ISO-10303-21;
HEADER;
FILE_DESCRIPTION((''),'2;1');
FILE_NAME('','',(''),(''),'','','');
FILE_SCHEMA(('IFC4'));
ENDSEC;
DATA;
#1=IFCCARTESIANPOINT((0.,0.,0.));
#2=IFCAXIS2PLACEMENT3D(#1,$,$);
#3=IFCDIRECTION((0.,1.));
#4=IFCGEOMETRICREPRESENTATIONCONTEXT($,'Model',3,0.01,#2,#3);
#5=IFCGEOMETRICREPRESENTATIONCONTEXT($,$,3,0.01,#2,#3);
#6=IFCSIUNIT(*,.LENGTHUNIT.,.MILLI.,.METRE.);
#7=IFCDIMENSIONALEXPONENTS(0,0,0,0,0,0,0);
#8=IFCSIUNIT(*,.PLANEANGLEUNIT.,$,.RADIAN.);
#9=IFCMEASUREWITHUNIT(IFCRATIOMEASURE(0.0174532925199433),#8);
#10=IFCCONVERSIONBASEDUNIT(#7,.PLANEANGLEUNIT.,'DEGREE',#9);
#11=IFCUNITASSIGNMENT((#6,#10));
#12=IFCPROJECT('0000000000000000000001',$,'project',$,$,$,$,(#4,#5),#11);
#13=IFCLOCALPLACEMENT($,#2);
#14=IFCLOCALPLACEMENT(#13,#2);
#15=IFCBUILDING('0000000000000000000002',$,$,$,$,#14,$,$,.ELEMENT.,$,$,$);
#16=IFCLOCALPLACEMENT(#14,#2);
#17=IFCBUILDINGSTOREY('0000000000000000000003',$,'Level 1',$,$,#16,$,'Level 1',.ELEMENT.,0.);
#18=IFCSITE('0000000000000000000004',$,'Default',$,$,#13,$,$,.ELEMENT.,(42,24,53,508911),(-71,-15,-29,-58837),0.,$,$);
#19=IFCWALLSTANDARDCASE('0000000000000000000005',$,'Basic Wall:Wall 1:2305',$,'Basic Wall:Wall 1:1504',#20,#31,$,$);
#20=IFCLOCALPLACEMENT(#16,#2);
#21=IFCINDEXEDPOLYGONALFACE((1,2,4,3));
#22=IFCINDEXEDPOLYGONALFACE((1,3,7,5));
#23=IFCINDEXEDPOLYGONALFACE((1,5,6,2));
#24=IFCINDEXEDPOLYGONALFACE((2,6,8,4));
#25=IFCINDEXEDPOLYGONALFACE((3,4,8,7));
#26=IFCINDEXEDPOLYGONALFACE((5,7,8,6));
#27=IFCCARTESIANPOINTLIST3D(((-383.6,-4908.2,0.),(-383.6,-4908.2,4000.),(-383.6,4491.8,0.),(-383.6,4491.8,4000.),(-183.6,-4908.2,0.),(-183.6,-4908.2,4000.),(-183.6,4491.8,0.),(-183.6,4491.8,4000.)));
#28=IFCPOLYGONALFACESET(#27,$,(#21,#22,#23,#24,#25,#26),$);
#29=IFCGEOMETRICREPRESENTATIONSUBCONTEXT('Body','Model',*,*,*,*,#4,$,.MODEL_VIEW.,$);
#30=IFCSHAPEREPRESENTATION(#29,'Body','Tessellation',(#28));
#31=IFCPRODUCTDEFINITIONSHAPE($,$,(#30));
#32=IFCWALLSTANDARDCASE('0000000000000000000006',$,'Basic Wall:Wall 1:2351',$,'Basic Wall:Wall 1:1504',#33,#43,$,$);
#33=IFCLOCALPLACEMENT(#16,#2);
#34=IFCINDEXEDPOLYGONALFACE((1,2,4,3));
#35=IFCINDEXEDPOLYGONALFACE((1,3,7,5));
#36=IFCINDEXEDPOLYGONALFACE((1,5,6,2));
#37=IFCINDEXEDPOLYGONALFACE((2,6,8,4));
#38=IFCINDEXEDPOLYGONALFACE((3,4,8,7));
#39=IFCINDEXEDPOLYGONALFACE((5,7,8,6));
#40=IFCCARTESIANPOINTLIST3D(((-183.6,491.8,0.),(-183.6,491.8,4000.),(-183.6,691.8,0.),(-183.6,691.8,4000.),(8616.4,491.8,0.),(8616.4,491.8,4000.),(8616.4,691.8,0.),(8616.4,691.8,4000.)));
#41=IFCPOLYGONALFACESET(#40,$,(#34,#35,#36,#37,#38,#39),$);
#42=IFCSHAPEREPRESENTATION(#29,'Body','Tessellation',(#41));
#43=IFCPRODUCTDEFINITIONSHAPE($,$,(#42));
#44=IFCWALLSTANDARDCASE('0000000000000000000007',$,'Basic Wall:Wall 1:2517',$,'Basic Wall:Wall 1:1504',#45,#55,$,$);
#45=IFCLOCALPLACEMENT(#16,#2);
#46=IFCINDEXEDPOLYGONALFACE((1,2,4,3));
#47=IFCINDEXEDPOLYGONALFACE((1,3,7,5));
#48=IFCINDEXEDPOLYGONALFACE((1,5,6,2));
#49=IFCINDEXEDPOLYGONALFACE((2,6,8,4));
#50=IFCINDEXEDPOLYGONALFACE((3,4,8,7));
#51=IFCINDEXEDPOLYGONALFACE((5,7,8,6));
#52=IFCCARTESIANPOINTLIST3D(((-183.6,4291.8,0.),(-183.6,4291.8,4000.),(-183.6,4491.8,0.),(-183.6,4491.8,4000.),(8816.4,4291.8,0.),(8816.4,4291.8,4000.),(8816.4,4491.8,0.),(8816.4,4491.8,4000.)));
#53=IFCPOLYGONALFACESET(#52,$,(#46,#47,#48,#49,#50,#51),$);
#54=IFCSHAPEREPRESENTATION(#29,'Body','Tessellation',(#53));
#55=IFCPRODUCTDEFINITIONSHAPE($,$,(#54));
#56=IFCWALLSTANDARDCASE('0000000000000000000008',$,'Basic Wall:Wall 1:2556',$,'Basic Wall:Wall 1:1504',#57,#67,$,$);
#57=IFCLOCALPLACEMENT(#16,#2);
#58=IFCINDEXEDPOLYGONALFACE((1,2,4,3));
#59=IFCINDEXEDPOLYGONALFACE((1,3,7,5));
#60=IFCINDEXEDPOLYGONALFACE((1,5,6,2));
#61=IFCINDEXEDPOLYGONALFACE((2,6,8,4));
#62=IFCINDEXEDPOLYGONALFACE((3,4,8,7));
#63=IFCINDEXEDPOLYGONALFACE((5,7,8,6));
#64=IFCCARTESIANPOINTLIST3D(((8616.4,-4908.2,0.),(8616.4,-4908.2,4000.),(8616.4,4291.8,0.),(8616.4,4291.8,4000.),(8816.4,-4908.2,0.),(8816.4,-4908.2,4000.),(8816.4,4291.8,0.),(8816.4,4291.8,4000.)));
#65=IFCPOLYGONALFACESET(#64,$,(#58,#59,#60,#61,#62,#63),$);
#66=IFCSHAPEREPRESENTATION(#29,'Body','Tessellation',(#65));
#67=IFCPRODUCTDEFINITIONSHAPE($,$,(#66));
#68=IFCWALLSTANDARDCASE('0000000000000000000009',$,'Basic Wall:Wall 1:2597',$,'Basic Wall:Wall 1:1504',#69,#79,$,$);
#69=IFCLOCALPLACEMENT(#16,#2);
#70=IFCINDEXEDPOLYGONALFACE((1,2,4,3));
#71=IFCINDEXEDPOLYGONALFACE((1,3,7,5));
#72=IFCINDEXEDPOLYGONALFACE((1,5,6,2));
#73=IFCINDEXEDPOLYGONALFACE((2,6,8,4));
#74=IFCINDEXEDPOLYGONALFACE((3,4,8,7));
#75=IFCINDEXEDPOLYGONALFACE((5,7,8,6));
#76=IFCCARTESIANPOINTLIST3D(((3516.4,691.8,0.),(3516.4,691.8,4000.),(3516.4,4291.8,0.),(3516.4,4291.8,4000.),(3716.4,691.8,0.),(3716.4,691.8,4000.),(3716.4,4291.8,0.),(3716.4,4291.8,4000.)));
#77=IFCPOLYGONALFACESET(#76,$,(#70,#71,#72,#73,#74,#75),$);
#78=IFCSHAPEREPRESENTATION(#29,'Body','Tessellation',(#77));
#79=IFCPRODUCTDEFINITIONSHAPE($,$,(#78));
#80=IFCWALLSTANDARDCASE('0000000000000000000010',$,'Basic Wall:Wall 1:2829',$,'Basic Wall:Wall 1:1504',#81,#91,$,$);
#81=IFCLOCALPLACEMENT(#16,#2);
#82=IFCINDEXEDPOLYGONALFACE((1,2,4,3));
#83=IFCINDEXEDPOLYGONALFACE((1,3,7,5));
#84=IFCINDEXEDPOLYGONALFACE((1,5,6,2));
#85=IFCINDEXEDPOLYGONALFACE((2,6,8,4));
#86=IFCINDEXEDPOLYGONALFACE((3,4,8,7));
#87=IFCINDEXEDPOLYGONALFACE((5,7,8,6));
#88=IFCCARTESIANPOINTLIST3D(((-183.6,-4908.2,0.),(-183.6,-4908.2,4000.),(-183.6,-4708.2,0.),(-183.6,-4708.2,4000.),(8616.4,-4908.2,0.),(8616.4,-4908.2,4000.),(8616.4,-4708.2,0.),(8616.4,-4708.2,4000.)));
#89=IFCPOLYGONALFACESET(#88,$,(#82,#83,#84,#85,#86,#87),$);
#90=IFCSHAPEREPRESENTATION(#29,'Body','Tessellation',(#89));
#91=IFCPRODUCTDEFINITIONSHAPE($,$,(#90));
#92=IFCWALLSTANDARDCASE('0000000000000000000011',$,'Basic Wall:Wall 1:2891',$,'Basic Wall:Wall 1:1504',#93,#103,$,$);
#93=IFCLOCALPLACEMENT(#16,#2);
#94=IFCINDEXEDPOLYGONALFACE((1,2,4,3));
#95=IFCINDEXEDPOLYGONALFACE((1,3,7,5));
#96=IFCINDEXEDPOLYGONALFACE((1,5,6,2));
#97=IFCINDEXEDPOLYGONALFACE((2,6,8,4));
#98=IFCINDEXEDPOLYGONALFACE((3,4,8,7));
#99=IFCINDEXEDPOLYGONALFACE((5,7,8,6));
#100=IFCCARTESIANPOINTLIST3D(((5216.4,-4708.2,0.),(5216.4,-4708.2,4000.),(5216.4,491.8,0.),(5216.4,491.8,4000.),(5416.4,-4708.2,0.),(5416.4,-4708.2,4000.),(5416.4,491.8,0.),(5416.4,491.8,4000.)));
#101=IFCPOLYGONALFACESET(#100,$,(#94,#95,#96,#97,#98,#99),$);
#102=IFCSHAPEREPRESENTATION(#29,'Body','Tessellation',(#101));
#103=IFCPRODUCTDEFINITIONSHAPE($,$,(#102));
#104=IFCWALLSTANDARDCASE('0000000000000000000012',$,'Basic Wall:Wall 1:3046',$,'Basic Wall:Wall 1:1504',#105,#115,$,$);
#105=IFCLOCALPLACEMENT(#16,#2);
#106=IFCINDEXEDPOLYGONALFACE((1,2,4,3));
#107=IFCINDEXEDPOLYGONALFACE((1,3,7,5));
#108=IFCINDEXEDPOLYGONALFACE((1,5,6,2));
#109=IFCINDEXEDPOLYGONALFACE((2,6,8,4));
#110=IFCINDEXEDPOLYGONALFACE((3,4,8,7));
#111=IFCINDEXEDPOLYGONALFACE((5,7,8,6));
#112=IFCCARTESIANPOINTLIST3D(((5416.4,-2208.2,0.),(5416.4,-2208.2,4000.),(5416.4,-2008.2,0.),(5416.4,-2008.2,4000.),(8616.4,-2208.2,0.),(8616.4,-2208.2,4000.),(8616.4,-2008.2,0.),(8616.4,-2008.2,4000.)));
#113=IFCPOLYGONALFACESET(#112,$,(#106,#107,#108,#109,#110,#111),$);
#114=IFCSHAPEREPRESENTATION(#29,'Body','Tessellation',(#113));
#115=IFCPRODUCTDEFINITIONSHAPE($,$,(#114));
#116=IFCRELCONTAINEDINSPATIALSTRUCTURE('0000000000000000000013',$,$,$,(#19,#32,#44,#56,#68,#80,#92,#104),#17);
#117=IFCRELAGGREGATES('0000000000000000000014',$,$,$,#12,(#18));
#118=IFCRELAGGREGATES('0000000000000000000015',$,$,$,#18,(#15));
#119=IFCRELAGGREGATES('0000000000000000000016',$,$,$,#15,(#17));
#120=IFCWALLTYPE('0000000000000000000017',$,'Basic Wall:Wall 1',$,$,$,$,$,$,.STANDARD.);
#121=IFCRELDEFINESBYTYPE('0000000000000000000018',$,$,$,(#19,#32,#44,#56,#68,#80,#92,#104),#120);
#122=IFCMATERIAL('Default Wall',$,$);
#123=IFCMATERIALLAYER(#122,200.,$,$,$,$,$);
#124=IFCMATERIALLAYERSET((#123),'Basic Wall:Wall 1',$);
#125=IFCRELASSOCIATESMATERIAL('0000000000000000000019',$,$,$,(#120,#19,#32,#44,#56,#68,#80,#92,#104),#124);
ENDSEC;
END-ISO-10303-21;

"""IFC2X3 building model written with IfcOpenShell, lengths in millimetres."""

from ifc_helpers import new_model, entity, si_unit, converted_unit, direction, frame, frame_2d, origin, place, context, subcontext, project, spatial, rectangle, extrude, material, layer, layer_set, layer_usage, type_object, element, save


model = new_model("IFC2X3")

# Units and contexts
model_context = context("Model", 3, precision=0.01, world=origin(), true_north=direction((0.0, 1.0)))
context_of_model = context(None, 3, precision=0.01, world=origin(), true_north=direction((0.0, 1.0)))
body_context = subcontext(model_context, "Body", "Model", "MODEL_VIEW")
ifc_project = project(units=[si_unit("LENGTHUNIT", "METRE", prefix="MILLI"), converted_unit("PLANEANGLEUNIT", "DEGREE", entity("IfcRatioMeasure", 0.0174532925199433), si_unit("PLANEANGLEUNIT", "RADIAN"), dimensions=[0, 0, 0, 0, 0, 0, 0])], contexts=[model_context, context_of_model])

# Site, building, storey
site_placement = place(None, origin())
site = spatial("IfcSite", under=ifc_project, at=site_placement, Name="Default", CompositionType="ELEMENT", RefLatitude=(42, 24, 53, 508911), RefLongitude=(-71, -15, -29, -58837), RefElevation=0.0)
building_placement = place(site_placement, origin())
building = spatial("IfcBuilding", under=site, at=building_placement, CompositionType="ELEMENT")
storey_placement = place(building_placement, origin())
storey = spatial("IfcBuildingStorey", under=building, at=storey_placement, Name="Level 1", LongName="Level 1", CompositionType="ELEMENT", Elevation=0.0)

# Walls
ifc_material = material(Name="Default Wall")
ifc_layer = layer(ifc_material, 200.0)
ifc_layer_set = layer_set([ifc_layer], Name="Basic Wall:Wall 1")
ifc_layer_usage_1 = layer_usage(ifc_layer_set, "AXIS2", "NEGATIVE", 100.0)
wall_type = type_object("IfcWallType", Name="Basic Wall:Wall 1", PredefinedType="STANDARD", material=ifc_layer_set)
wall_1_placement = place(storey_placement, frame((-283.6, 4491.8, 0.0), z_axis=(0.0, 0.0, 1.0), x_axis=(0.0, -1.0, 0.0)))
element("IfcWallStandardCase", 1, at=wall_1_placement, inside=storey, type_object=wall_type, material=ifc_layer_usage_1, Name="Basic Wall:Wall 1:2305", ObjectType="Basic Wall:Wall 1:1504", context=body_context, shape_type="SweptSolid", body=[
    extrude(rectangle(XDim=9400.0, YDim=200.0, at=frame_2d((4700.0, 0.0), x_axis=(-1.0, 0.0))), origin(), (0.0, 0.0, 1.0), 4000.0),
])
ifc_layer_usage_2 = layer_usage(ifc_layer_set, "AXIS2", "NEGATIVE", 100.0)
wall_2_placement = place(storey_placement, frame((-183.6, 591.8, 0.0)))
element("IfcWallStandardCase", 2, at=wall_2_placement, inside=storey, type_object=wall_type, material=ifc_layer_usage_2, Name="Basic Wall:Wall 1:2351", ObjectType="Basic Wall:Wall 1:1504", context=body_context, shape_type="SweptSolid", body=[
    extrude(rectangle(XDim=8800.0, YDim=200.0, at=frame_2d((4400.0, 0.0), x_axis=(-1.0, 0.0))), origin(), (0.0, 0.0, 1.0), 4000.0),
])
ifc_layer_usage_3 = layer_usage(ifc_layer_set, "AXIS2", "NEGATIVE", 100.0)
wall_3_placement = place(storey_placement, frame((-183.6, 4391.8, 0.0)))
element("IfcWallStandardCase", 3, at=wall_3_placement, inside=storey, type_object=wall_type, material=ifc_layer_usage_3, Name="Basic Wall:Wall 1:2517", ObjectType="Basic Wall:Wall 1:1504", context=body_context, shape_type="SweptSolid", body=[
    extrude(rectangle(XDim=9000.0, YDim=200.0, at=frame_2d((4500.0, 0.0), x_axis=(-1.0, 0.0))), origin(), (0.0, 0.0, 1.0), 4000.0),
])
ifc_layer_usage_4 = layer_usage(ifc_layer_set, "AXIS2", "NEGATIVE", 100.0)
wall_4_placement = place(storey_placement, frame((8716.4, 4291.8, 0.0), z_axis=(0.0, 0.0, 1.0), x_axis=(0.0, -1.0, 0.0)))
element("IfcWallStandardCase", 4, at=wall_4_placement, inside=storey, type_object=wall_type, material=ifc_layer_usage_4, Name="Basic Wall:Wall 1:2556", ObjectType="Basic Wall:Wall 1:1504", context=body_context, shape_type="SweptSolid", body=[
    extrude(rectangle(XDim=9200.0, YDim=200.0, at=frame_2d((4600.0, 0.0), x_axis=(-1.0, 0.0))), origin(), (0.0, 0.0, 1.0), 4000.0),
])
ifc_layer_usage_5 = layer_usage(ifc_layer_set, "AXIS2", "NEGATIVE", 100.0)
wall_5_placement = place(storey_placement, frame((3616.4, 691.8, 0.0), z_axis=(0.0, 0.0, 1.0), x_axis=(0.0, 1.0, 0.0)))
element("IfcWallStandardCase", 5, at=wall_5_placement, inside=storey, type_object=wall_type, material=ifc_layer_usage_5, Name="Basic Wall:Wall 1:2597", ObjectType="Basic Wall:Wall 1:1504", context=body_context, shape_type="SweptSolid", body=[
    extrude(rectangle(XDim=3600.0, YDim=200.0, at=frame_2d((1800.0, 0.0), x_axis=(-1.0, 0.0))), origin(), (0.0, 0.0, 1.0), 4000.0),
])
ifc_layer_usage_6 = layer_usage(ifc_layer_set, "AXIS2", "NEGATIVE", 100.0)
wall_6_placement = place(storey_placement, frame((-183.6, -4808.2, 0.0)))
element("IfcWallStandardCase", 6, at=wall_6_placement, inside=storey, type_object=wall_type, material=ifc_layer_usage_6, Name="Basic Wall:Wall 1:2829", ObjectType="Basic Wall:Wall 1:1504", context=body_context, shape_type="SweptSolid", body=[
    extrude(rectangle(XDim=8800.0, YDim=200.0, at=frame_2d((4400.0, 0.0), x_axis=(-1.0, 0.0))), origin(), (0.0, 0.0, 1.0), 4000.0),
])
ifc_layer_usage_7 = layer_usage(ifc_layer_set, "AXIS2", "NEGATIVE", 100.0)
wall_7_placement = place(storey_placement, frame((5316.4, -4708.2, 0.0), z_axis=(0.0, 0.0, 1.0), x_axis=(0.0, 1.0, 0.0)))
element("IfcWallStandardCase", 7, at=wall_7_placement, inside=storey, type_object=wall_type, material=ifc_layer_usage_7, Name="Basic Wall:Wall 1:2891", ObjectType="Basic Wall:Wall 1:1504", context=body_context, shape_type="SweptSolid", body=[
    extrude(rectangle(XDim=5200.0, YDim=200.0, at=frame_2d((2600.0, 0.0), x_axis=(-1.0, 0.0))), origin(), (0.0, 0.0, 1.0), 4000.0),
])
ifc_layer_usage_8 = layer_usage(ifc_layer_set, "AXIS2", "NEGATIVE", 100.0)
wall_8_placement = place(storey_placement, frame((5416.4, -2108.2, 0.0)))
element("IfcWallStandardCase", 8, at=wall_8_placement, inside=storey, type_object=wall_type, material=ifc_layer_usage_8, Name="Basic Wall:Wall 1:3046", ObjectType="Basic Wall:Wall 1:1504", context=body_context, shape_type="SweptSolid", body=[
    extrude(rectangle(XDim=3200.0, YDim=200.0, at=frame_2d((1600.0, 0.0), x_axis=(-1.0, 0.0))), origin(), (0.0, 0.0, 1.0), 4000.0),
])

save(model, "model.ifc")
